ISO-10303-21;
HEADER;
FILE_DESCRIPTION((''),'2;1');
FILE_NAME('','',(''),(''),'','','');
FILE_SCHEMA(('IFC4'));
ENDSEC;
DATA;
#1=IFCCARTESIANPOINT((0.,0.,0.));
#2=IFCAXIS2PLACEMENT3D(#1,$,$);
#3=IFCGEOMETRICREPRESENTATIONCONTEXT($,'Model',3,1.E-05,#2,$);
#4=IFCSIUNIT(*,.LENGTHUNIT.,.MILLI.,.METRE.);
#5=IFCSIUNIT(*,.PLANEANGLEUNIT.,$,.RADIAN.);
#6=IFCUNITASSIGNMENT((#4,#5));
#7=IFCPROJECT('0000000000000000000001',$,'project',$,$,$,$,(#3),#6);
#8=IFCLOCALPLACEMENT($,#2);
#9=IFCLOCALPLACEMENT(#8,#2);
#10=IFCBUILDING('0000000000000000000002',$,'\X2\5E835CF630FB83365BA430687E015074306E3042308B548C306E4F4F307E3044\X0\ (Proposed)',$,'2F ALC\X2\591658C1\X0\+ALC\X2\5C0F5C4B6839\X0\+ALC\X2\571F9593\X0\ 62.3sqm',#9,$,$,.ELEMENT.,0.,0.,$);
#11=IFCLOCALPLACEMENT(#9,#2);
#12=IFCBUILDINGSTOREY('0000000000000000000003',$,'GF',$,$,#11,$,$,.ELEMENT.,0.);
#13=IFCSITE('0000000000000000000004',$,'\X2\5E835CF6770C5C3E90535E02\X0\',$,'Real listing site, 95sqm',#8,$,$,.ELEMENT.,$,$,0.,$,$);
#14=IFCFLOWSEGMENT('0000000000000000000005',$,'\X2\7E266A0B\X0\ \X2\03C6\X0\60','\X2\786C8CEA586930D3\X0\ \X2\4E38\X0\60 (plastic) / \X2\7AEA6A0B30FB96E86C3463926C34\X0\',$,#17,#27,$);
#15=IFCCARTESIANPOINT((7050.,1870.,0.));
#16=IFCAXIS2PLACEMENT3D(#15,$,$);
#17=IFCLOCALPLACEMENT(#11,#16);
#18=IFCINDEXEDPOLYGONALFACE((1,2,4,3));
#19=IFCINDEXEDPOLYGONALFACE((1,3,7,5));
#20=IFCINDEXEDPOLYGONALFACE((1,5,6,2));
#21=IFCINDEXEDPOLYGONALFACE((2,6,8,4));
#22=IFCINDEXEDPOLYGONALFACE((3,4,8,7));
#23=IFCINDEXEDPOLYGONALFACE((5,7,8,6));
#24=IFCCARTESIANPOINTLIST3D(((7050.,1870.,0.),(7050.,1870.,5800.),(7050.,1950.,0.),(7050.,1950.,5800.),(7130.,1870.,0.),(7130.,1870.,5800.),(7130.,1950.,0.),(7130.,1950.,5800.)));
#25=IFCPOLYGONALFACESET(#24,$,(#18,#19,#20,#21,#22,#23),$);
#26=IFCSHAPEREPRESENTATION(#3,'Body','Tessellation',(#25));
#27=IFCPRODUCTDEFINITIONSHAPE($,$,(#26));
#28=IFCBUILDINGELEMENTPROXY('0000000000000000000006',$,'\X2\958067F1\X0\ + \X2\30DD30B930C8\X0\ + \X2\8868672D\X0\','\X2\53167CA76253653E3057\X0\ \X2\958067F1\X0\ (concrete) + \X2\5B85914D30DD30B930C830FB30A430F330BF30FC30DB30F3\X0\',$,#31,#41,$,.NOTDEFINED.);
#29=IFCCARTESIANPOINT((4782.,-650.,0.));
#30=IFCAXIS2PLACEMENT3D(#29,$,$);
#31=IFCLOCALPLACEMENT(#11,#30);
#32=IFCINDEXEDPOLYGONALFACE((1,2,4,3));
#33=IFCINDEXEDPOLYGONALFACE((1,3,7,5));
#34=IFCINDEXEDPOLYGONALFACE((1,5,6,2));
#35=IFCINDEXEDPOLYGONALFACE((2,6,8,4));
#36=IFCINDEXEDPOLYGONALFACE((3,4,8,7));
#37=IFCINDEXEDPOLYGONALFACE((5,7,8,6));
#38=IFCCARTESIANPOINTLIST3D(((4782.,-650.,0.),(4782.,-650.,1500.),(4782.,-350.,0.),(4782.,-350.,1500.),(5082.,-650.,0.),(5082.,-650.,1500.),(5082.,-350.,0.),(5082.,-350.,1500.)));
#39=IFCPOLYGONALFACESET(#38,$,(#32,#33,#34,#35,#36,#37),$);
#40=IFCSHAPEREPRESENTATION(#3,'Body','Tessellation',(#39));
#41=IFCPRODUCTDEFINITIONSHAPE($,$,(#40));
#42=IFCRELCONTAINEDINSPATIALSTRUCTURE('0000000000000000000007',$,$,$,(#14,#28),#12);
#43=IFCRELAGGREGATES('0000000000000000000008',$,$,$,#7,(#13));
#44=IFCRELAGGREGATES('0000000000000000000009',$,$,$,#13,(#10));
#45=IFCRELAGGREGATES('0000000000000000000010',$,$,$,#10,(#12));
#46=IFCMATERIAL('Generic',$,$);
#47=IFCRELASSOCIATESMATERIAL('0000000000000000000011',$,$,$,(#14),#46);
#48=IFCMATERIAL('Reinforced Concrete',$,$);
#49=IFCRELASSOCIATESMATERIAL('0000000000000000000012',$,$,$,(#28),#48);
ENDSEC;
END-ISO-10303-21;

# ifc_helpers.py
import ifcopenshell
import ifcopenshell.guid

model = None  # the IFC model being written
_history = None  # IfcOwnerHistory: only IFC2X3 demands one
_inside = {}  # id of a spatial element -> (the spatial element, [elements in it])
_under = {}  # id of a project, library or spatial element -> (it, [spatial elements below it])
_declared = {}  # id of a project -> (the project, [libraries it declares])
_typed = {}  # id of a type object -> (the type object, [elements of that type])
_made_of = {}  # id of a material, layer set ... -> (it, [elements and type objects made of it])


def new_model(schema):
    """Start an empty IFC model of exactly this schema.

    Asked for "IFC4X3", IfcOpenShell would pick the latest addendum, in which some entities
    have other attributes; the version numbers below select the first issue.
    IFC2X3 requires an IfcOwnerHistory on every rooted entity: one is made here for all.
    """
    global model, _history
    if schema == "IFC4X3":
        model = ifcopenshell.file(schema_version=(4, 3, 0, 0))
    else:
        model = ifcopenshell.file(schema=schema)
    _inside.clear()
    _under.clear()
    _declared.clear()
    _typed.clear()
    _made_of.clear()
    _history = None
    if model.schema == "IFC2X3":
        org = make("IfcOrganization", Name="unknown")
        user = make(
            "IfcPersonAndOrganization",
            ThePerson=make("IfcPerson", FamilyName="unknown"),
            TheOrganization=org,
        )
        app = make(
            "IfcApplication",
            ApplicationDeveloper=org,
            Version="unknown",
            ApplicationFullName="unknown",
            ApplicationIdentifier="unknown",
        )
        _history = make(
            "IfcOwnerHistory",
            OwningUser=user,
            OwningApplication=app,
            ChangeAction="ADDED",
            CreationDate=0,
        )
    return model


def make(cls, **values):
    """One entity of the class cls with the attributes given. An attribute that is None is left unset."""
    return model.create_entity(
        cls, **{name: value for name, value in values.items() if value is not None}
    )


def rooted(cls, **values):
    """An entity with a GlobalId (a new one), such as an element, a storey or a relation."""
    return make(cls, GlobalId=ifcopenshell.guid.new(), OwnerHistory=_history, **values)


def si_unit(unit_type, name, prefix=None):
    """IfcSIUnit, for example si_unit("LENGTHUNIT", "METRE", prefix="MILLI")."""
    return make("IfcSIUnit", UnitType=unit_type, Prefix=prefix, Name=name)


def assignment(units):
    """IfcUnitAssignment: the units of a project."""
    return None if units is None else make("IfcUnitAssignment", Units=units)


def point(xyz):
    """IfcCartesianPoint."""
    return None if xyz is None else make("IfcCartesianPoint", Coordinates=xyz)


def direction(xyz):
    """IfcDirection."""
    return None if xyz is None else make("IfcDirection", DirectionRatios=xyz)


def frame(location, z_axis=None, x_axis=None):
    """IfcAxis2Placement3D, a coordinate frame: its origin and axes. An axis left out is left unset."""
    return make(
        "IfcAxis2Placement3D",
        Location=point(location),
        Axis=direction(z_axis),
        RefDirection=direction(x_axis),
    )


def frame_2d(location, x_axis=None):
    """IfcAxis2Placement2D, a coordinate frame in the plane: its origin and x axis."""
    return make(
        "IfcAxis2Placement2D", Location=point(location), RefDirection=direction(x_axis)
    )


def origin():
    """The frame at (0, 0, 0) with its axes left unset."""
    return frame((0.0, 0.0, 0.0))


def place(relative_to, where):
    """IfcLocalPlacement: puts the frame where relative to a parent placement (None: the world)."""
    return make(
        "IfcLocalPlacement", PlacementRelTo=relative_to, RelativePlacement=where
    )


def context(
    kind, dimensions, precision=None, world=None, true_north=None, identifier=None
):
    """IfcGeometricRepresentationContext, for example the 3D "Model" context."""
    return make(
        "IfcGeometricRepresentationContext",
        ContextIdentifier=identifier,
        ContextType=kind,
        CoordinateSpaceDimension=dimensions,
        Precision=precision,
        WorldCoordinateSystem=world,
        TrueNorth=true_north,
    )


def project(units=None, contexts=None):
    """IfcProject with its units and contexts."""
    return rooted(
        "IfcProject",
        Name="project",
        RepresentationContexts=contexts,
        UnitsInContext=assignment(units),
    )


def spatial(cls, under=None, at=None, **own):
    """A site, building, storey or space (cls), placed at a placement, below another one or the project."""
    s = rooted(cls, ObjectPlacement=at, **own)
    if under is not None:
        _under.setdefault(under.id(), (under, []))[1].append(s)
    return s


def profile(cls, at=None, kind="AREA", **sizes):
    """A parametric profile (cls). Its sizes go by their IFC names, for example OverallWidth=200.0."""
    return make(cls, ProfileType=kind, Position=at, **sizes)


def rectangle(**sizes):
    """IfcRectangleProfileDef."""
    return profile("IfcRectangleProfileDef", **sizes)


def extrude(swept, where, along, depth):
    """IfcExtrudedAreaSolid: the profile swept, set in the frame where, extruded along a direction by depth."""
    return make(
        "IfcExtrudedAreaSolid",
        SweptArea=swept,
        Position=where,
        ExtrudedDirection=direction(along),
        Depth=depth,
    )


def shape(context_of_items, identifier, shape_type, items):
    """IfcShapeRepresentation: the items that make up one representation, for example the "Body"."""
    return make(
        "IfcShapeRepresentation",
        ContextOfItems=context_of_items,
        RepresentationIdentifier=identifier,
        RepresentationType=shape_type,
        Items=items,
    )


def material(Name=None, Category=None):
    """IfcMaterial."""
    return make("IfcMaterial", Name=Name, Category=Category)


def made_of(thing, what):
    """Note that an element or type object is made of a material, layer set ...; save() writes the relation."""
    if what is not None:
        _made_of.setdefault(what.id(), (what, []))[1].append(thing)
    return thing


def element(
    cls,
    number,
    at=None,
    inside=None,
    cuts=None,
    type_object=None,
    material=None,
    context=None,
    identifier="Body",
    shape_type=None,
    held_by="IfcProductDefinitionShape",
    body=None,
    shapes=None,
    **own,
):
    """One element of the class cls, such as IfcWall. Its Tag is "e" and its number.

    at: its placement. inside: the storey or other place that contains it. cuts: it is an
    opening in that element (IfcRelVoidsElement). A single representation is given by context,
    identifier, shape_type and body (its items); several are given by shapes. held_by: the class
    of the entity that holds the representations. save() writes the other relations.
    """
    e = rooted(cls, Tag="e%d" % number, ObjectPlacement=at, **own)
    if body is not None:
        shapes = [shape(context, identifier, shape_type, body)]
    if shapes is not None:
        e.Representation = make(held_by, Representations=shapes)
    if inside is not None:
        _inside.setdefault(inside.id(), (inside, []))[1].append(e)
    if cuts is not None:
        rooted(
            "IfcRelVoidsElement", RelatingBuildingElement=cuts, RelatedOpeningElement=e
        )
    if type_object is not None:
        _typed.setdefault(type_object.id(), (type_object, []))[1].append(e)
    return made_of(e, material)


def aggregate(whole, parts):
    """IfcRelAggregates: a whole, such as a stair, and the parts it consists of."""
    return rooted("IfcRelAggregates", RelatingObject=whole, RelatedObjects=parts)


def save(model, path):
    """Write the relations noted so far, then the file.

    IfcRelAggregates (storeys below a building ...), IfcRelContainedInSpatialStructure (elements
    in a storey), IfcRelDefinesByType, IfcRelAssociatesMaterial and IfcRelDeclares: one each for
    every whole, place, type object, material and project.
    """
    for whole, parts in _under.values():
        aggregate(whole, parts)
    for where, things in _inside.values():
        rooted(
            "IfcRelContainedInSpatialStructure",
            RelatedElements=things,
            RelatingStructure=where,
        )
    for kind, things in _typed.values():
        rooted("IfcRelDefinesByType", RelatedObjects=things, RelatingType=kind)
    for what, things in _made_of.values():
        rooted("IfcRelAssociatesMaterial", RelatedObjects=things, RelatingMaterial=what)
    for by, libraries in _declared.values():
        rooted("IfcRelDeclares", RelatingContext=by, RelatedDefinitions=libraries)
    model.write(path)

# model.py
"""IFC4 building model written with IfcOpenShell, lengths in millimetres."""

from ifc_helpers import new_model, si_unit, frame, frame_2d, origin, place, context, project, spatial, rectangle, extrude, material, element, save


model = new_model("IFC4")

# Units and contexts
model_context = context("Model", 3, precision=1e-05, world=origin())
ifc_project = project(units=[si_unit("LENGTHUNIT", "METRE", prefix="MILLI"), si_unit("PLANEANGLEUNIT", "RADIAN")], contexts=[model_context])

# Site, building, storey
site_placement = place(None, origin())
site = spatial("IfcSite", under=ifc_project, at=site_placement, Name="広島県尾道市", ObjectType="Real listing site, 95sqm", CompositionType="ELEMENT", RefElevation=0.0)
building_placement = place(site_placement, origin())
building = spatial("IfcBuilding", under=site, at=building_placement, Name="広島・茶室と縁側のある和の住まい (Proposed)", ObjectType="2F ALC外壁+ALC小屋根+ALC土間 62.3sqm", CompositionType="ELEMENT", ElevationOfRefHeight=0.0, ElevationOfTerrain=0.0)
storey_placement = place(building_placement, origin())
storey = spatial("IfcBuildingStorey", under=building, at=storey_placement, Name="GF", CompositionType="ELEMENT", Elevation=0.0)

# Shared definitions
ifc_material_1 = material(Name="Generic")
ifc_material_2 = material(Name="Reinforced Concrete")

# Flow segment
flow_segment_placement = place(storey_placement, frame((7050.0, 1870.0, 0.0)))
element("IfcFlowSegment", 1, at=flow_segment_placement, inside=storey, material=ifc_material_1, Name="縦樋 φ60", Description="硬質塩ビ 丸60 (plastic) / 竪樋・雨水排水", context=model_context, shape_type="SweptSolid", body=[
    extrude(rectangle(XDim=80.0, YDim=80.0, at=frame_2d((40.0, 40.0))), frame((7050.0, 1870.0, 0.0)), (0.0, 0.0, 1.0), 5800.0),
])

# Building element proxy
proxy_placement = place(storey_placement, frame((4782.0, -650.0, 0.0)))
element("IfcBuildingElementProxy", 2, at=proxy_placement, inside=storey, material=ifc_material_2, Name="門柱 + ポスト + 表札", Description="化粧打放し 門柱 (concrete) + 宅配ポスト・インターホン", PredefinedType="NOTDEFINED", context=model_context, shape_type="SweptSolid", body=[
    extrude(rectangle(XDim=300.0, YDim=300.0, at=frame_2d((150.0, 150.0))), frame((4782.0, -650.0, 0.0)), (0.0, 0.0, 1.0), 1500.0),
])

save(model, "model.ifc")
